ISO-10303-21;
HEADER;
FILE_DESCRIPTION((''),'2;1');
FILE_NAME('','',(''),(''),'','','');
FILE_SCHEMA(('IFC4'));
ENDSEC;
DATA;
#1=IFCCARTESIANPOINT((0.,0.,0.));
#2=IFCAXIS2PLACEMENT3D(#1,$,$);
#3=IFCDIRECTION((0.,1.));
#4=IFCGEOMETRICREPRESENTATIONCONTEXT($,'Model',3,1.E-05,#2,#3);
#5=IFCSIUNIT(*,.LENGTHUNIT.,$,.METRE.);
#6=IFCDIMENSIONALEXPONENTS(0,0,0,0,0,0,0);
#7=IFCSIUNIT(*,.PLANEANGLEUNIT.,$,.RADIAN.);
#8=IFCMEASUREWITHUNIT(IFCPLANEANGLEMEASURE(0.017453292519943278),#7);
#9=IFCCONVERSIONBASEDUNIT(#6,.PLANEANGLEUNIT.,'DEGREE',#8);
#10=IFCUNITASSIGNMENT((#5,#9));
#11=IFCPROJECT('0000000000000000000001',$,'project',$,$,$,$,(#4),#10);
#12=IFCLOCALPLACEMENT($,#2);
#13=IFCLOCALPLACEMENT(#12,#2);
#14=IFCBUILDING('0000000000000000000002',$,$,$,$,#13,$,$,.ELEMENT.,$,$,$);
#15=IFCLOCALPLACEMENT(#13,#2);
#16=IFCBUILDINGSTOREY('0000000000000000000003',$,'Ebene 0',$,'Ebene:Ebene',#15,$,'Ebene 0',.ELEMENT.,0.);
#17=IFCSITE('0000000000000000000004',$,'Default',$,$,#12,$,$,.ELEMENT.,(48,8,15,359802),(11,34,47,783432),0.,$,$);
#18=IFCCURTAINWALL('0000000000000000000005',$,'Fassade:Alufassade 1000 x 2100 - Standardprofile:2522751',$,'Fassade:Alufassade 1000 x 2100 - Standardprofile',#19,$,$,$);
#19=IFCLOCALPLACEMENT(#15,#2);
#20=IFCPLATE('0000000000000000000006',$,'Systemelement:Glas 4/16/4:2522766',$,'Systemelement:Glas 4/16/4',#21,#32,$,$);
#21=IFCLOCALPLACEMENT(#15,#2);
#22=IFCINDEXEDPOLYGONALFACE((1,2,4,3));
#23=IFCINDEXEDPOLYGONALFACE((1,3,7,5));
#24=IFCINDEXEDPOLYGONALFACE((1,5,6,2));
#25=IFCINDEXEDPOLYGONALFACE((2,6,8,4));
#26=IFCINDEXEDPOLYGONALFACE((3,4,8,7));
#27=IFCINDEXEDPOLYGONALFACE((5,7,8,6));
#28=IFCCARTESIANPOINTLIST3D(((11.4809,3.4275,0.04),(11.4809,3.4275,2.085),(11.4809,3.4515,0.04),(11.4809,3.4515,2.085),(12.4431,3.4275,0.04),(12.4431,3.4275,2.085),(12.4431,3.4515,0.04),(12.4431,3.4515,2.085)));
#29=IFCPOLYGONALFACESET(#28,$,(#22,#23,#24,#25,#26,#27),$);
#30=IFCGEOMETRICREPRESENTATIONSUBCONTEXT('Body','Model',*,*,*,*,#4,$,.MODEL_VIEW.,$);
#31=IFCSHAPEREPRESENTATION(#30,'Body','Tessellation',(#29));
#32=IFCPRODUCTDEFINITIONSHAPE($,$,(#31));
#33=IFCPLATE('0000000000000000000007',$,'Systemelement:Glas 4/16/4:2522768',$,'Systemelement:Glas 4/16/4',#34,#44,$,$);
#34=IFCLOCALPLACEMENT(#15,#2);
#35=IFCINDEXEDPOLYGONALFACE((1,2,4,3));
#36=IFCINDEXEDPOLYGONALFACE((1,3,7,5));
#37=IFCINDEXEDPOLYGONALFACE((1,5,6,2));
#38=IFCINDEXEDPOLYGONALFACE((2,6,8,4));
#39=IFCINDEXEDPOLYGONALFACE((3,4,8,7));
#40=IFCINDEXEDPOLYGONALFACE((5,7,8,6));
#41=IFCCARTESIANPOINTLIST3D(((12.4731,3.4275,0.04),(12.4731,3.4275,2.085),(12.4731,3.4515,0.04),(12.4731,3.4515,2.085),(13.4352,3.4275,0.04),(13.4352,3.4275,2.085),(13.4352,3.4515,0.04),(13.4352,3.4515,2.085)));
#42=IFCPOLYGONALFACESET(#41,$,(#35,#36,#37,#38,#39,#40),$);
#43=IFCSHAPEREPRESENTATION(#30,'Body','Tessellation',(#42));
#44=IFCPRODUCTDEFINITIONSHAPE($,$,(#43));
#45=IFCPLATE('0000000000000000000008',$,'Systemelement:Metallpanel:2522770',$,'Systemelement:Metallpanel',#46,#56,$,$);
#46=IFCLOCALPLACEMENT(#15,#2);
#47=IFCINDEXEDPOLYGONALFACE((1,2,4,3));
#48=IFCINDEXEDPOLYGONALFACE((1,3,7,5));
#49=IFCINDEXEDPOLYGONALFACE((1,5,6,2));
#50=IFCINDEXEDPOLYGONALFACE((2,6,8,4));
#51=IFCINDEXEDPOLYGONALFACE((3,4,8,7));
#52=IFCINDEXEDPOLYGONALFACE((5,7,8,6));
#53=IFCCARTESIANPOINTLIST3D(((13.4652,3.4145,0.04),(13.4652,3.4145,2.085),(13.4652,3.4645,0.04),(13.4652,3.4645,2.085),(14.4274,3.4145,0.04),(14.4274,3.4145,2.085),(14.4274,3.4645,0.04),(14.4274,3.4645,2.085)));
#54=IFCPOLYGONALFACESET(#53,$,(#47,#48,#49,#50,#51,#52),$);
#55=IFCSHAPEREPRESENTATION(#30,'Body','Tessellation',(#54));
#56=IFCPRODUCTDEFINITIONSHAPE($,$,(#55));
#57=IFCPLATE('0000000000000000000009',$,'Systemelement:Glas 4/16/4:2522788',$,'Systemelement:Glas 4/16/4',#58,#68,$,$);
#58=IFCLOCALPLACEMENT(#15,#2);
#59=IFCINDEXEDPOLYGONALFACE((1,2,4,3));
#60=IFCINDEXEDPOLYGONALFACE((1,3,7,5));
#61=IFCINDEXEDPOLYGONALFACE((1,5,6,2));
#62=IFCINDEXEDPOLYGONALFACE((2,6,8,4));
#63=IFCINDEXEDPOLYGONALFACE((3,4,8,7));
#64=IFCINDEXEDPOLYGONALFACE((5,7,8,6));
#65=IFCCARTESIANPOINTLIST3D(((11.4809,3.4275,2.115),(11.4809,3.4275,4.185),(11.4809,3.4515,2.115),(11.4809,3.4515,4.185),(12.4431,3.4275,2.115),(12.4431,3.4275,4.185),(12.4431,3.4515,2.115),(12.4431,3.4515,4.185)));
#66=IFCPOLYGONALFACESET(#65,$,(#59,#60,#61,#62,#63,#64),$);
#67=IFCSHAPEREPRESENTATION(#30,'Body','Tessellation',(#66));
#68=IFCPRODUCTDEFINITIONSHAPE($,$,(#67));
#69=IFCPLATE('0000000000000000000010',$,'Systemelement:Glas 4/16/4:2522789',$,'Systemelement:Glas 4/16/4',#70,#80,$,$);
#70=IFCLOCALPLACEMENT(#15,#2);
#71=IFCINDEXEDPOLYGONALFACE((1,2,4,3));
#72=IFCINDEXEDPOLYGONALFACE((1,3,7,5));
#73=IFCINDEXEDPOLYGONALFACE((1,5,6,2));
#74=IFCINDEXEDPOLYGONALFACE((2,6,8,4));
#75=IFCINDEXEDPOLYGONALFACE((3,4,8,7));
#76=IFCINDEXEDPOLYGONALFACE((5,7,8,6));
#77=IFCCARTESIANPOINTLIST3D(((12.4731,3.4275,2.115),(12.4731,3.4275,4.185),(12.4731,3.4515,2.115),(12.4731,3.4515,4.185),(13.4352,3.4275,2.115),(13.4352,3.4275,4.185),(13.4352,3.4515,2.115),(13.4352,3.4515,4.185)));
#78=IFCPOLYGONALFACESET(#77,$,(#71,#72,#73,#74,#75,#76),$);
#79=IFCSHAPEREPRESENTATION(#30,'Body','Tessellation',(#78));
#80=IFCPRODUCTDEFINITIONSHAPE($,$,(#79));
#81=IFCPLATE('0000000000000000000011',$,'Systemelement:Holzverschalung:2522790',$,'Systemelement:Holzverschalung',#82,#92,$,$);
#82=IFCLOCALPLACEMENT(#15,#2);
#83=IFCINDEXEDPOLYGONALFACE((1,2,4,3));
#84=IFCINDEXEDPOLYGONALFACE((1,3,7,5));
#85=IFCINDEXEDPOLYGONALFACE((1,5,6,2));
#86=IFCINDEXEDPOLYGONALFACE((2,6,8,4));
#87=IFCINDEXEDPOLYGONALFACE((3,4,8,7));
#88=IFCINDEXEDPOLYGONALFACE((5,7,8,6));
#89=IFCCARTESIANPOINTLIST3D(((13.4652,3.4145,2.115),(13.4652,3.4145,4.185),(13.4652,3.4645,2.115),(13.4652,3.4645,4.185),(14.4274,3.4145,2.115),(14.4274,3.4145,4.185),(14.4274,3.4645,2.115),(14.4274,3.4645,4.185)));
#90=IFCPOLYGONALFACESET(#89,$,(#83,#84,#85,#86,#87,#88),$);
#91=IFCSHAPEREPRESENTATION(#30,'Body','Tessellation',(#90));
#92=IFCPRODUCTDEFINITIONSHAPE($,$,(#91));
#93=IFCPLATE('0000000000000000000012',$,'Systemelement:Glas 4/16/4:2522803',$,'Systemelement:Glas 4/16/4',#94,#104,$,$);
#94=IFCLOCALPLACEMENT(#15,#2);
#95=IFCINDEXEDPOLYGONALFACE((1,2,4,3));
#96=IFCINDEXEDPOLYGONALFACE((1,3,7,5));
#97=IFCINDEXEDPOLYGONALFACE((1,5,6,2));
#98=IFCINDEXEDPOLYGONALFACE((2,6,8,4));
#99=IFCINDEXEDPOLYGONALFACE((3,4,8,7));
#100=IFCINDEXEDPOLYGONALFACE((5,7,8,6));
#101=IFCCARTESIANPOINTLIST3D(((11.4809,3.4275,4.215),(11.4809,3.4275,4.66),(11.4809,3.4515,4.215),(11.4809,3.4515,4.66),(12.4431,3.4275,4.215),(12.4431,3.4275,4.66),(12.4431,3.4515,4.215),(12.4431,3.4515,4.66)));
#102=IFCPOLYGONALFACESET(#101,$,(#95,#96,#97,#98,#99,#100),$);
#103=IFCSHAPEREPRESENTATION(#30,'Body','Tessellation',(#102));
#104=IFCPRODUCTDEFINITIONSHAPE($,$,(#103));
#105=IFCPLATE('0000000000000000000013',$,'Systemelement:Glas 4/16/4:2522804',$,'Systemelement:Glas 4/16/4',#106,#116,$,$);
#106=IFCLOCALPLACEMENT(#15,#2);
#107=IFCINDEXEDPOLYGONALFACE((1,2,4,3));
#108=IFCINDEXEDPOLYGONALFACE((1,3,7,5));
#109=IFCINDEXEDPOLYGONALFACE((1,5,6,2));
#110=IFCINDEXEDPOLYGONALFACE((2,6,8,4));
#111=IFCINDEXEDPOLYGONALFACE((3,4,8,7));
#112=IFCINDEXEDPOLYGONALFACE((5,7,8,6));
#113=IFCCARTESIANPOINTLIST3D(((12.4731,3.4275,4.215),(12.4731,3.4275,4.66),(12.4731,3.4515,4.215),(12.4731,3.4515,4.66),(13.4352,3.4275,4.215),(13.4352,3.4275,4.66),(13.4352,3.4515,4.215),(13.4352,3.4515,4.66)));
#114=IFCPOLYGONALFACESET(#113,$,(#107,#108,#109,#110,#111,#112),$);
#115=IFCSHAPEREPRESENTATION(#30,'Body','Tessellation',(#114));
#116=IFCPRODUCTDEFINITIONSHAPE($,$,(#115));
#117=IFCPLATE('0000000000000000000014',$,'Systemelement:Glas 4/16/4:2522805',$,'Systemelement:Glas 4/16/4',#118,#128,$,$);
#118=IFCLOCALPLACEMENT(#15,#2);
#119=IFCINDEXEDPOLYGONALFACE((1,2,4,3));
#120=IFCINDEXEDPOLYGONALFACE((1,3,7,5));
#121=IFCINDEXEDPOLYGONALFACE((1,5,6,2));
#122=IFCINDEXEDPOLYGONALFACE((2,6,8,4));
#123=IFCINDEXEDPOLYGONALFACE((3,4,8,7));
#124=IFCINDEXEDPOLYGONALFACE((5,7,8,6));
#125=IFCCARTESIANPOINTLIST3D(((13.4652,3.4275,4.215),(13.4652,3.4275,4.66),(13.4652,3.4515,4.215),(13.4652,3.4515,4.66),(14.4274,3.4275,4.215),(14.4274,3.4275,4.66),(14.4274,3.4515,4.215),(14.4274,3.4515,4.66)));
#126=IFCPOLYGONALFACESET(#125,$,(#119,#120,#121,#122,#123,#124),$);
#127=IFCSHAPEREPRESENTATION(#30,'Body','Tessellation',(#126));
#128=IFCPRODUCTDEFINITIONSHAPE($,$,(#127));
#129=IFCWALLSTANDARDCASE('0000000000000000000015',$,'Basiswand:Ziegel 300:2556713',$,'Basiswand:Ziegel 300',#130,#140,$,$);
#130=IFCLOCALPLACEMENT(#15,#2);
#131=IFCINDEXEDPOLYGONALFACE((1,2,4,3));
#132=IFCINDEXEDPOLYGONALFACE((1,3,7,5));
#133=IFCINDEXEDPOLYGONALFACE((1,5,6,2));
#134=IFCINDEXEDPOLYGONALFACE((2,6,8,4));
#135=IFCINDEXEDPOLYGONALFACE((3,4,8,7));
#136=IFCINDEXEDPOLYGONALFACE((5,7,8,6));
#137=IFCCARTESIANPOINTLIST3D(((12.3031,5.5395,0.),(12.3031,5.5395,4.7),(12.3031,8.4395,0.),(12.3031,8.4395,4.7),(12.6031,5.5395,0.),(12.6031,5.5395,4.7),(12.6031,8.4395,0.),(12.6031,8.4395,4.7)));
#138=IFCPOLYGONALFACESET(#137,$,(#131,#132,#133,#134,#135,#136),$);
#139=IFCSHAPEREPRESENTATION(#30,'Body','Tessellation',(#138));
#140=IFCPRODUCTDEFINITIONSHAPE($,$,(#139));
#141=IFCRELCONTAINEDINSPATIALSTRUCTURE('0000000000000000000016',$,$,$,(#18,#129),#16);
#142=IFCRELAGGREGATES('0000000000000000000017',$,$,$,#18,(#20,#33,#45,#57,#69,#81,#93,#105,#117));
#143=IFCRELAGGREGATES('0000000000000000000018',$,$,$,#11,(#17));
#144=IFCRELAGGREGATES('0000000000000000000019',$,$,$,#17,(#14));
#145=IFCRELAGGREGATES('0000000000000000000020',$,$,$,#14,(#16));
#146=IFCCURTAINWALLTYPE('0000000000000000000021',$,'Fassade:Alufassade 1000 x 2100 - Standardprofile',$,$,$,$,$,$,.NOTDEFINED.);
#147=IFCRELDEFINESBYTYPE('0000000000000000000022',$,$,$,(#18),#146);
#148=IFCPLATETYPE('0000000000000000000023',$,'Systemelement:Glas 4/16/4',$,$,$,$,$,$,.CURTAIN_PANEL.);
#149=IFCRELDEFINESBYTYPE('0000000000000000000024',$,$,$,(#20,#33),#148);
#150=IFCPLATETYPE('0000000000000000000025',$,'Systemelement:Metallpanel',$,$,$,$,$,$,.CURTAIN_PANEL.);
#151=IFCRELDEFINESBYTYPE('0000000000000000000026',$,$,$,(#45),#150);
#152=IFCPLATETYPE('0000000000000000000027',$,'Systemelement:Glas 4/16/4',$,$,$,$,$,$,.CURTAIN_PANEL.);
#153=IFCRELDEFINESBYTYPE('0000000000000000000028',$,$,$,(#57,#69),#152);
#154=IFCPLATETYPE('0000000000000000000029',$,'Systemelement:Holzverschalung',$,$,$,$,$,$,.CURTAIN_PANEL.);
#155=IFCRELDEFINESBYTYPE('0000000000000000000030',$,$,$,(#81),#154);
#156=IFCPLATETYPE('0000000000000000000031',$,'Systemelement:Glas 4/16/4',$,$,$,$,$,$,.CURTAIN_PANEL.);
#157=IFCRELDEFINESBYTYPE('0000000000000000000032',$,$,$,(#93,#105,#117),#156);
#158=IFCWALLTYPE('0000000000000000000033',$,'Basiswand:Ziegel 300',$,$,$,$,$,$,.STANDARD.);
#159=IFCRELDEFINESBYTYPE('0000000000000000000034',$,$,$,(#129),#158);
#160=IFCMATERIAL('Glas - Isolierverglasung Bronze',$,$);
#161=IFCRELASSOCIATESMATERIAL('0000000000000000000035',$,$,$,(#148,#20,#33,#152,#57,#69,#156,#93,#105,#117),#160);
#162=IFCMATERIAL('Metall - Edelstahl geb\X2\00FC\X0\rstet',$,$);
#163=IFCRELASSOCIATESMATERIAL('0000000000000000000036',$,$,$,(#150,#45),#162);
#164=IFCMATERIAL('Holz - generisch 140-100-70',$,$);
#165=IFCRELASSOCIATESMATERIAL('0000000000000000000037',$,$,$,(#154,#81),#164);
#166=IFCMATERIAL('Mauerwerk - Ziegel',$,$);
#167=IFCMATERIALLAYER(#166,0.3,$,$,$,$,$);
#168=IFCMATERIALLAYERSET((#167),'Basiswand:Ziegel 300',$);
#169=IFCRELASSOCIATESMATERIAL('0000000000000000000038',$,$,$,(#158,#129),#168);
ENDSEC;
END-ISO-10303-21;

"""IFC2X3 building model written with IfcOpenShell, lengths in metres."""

from ifc_helpers import new_model, entity, si_unit, converted_unit, direction, frame, frame_2d, origin, origin_2d_with_axis, place, context, subcontext, project, spatial, polyline, rectangle, extrude, clip, bounded_halfspace, source, transform, mapped, material, layer, layer_set, layer_usage, type_object, type_shapes, element, aggregate, save


model = new_model("IFC2X3")

# Units and contexts
model_context = context("Model", 3, precision=1e-05, world=origin(), true_north=direction((0.0, 1.0)))
body_context = subcontext(model_context, "Body", "Model", "MODEL_VIEW")
ifc_project = project(units=[si_unit("LENGTHUNIT", "METRE"), converted_unit("PLANEANGLEUNIT", "DEGREE", entity("IfcPlaneAngleMeasure", 0.017453292519943278), si_unit("PLANEANGLEUNIT", "RADIAN"), dimensions=[0, 0, 0, 0, 0, 0, 0])], contexts=[model_context])

# Site, building, storey
site_placement = place(None, origin())
site = spatial("IfcSite", under=ifc_project, at=site_placement, Name="Default", CompositionType="ELEMENT", RefLatitude=(48, 8, 15, 359802), RefLongitude=(11, 34, 47, 783432), RefElevation=0.0)
building_placement = place(site_placement, origin())
building = spatial("IfcBuilding", under=site, at=building_placement, CompositionType="ELEMENT")
storey_placement = place(building_placement, origin())
storey = spatial("IfcBuildingStorey", under=building, at=storey_placement, Name="Ebene 0", ObjectType="Ebene:Ebene", LongName="Ebene 0", CompositionType="ELEMENT", Elevation=0.0)

# Curtain wall, plates
curtain_wall_type = type_object("IfcCurtainWallType", Name="Fassade:Alufassade 1000 x 2100 - Standardprofile", PredefinedType="NOTDEFINED")
curtain_wall_placement = place(storey_placement, origin())
curtain_wall = element("IfcCurtainWall", 1, at=curtain_wall_placement, inside=storey, type_object=curtain_wall_type, Name="Fassade:Alufassade 1000 x 2100 - Standardprofile:2522751", ObjectType="Fassade:Alufassade 1000 x 2100 - Standardprofile")
ifc_material_1 = material(Name="Glas - Isolierverglasung Bronze")
plate_type_1 = type_object("IfcPlateType", Name="Systemelement:Glas 4/16/4", PredefinedType="CURTAIN_PANEL", material=ifc_material_1)
shared_shape_1 = source(origin(), body_context, "Body", "SweptSolid", [
    extrude(rectangle(XDim=0.024, YDim=0.9621, at=origin_2d_with_axis()), frame((0.0, 0.0, 0.0), z_axis=(0.0, 0.0, 1.0), x_axis=(0.0, 1.0, 0.0)), (0.0, 0.0, 1.0), 2.045),
])
type_shapes(plate_type_1, [shared_shape_1])
plate_1_placement = place(curtain_wall_placement, frame((11.962, 3.4395, 0.04)))
plate_1 = element("IfcPlate", 2, at=plate_1_placement, type_object=plate_type_1, material=ifc_material_1, Name="Systemelement:Glas 4/16/4:2522766", ObjectType="Systemelement:Glas 4/16/4", context=body_context, shape_type="MappedRepresentation", body=[
    mapped(shared_shape_1, transform((0.0, 0.0, 0.0), scale=1.0)),
])
plate_2_placement = place(curtain_wall_placement, frame((12.9542, 3.4395, 0.04)))
plate_2 = element("IfcPlate", 3, at=plate_2_placement, type_object=plate_type_1, material=ifc_material_1, Name="Systemelement:Glas 4/16/4:2522768", ObjectType="Systemelement:Glas 4/16/4", context=body_context, shape_type="MappedRepresentation", body=[
    mapped(shared_shape_1, transform((0.0, 0.0, 0.0), scale=1.0)),
])
ifc_material_2 = material(Name="Metall - Edelstahl gebürstet")
plate_type_2 = type_object("IfcPlateType", Name="Systemelement:Metallpanel", PredefinedType="CURTAIN_PANEL", material=ifc_material_2)
shared_shape_2 = source(origin(), body_context, "Body", "SweptSolid", [
    extrude(rectangle(XDim=0.05, YDim=0.9621, at=origin_2d_with_axis()), frame((0.0, 0.0, 0.0), z_axis=(0.0, 0.0, 1.0), x_axis=(0.0, 1.0, 0.0)), (0.0, 0.0, 1.0), 2.045),
])
type_shapes(plate_type_2, [shared_shape_2])
plate_3_placement = place(curtain_wall_placement, frame((13.9463, 3.4395, 0.04)))
plate_3 = element("IfcPlate", 4, at=plate_3_placement, type_object=plate_type_2, material=ifc_material_2, Name="Systemelement:Metallpanel:2522770", ObjectType="Systemelement:Metallpanel", context=body_context, shape_type="MappedRepresentation", body=[
    mapped(shared_shape_2, transform((0.0, 0.0, 0.0), scale=1.0)),
])
plate_type_3 = type_object("IfcPlateType", Name="Systemelement:Glas 4/16/4", PredefinedType="CURTAIN_PANEL", material=ifc_material_1)
shared_shape_3 = source(origin(), body_context, "Body", "SweptSolid", [
    extrude(rectangle(XDim=0.024, YDim=0.9621, at=origin_2d_with_axis()), frame((0.0, 0.0, 0.0), z_axis=(0.0, 0.0, 1.0), x_axis=(0.0, 1.0, 0.0)), (0.0, 0.0, 1.0), 2.07),
])
type_shapes(plate_type_3, [shared_shape_3])
plate_4_placement = place(curtain_wall_placement, frame((11.962, 3.4395, 2.115)))
plate_4 = element("IfcPlate", 5, at=plate_4_placement, type_object=plate_type_3, material=ifc_material_1, Name="Systemelement:Glas 4/16/4:2522788", ObjectType="Systemelement:Glas 4/16/4", context=body_context, shape_type="MappedRepresentation", body=[
    mapped(shared_shape_3, transform((0.0, 0.0, 0.0), scale=1.0)),
])
plate_5_placement = place(curtain_wall_placement, frame((12.9542, 3.4395, 2.115)))
plate_5 = element("IfcPlate", 6, at=plate_5_placement, type_object=plate_type_3, material=ifc_material_1, Name="Systemelement:Glas 4/16/4:2522789", ObjectType="Systemelement:Glas 4/16/4", context=body_context, shape_type="MappedRepresentation", body=[
    mapped(shared_shape_3, transform((0.0, 0.0, 0.0), scale=1.0)),
])
ifc_material_3 = material(Name="Holz - generisch 140-100-70")
plate_type_4 = type_object("IfcPlateType", Name="Systemelement:Holzverschalung", PredefinedType="CURTAIN_PANEL", material=ifc_material_3)
shared_shape_4 = source(origin(), body_context, "Body", "SweptSolid", [
    extrude(rectangle(XDim=0.05, YDim=0.9621, at=origin_2d_with_axis()), frame((0.0, 0.0, 0.0), z_axis=(0.0, 0.0, 1.0), x_axis=(0.0, 1.0, 0.0)), (0.0, 0.0, 1.0), 2.07),
])
type_shapes(plate_type_4, [shared_shape_4])
plate_6_placement = place(curtain_wall_placement, frame((13.9463, 3.4395, 2.115)))
plate_6 = element("IfcPlate", 7, at=plate_6_placement, type_object=plate_type_4, material=ifc_material_3, Name="Systemelement:Holzverschalung:2522790", ObjectType="Systemelement:Holzverschalung", context=body_context, shape_type="MappedRepresentation", body=[
    mapped(shared_shape_4, transform((0.0, 0.0, 0.0), scale=1.0)),
])
plate_type_5 = type_object("IfcPlateType", Name="Systemelement:Glas 4/16/4", PredefinedType="CURTAIN_PANEL", material=ifc_material_1)
shared_shape_5 = source(origin(), body_context, "Body", "SweptSolid", [
    extrude(rectangle(XDim=0.024, YDim=0.9621, at=origin_2d_with_axis()), frame((0.0, 0.0, 0.0), z_axis=(0.0, 0.0, 1.0), x_axis=(0.0, 1.0, 0.0)), (0.0, 0.0, 1.0), 0.445),
])
type_shapes(plate_type_5, [shared_shape_5])
plate_7_placement = place(curtain_wall_placement, frame((11.962, 3.4395, 4.215)))
plate_7 = element("IfcPlate", 8, at=plate_7_placement, type_object=plate_type_5, material=ifc_material_1, Name="Systemelement:Glas 4/16/4:2522803", ObjectType="Systemelement:Glas 4/16/4", context=body_context, shape_type="MappedRepresentation", body=[
    mapped(shared_shape_5, transform((0.0, 0.0, 0.0), scale=1.0)),
])
plate_8_placement = place(curtain_wall_placement, frame((12.9542, 3.4395, 4.215)))
plate_8 = element("IfcPlate", 9, at=plate_8_placement, type_object=plate_type_5, material=ifc_material_1, Name="Systemelement:Glas 4/16/4:2522804", ObjectType="Systemelement:Glas 4/16/4", context=body_context, shape_type="MappedRepresentation", body=[
    mapped(shared_shape_5, transform((0.0, 0.0, 0.0), scale=1.0)),
])
plate_9_placement = place(curtain_wall_placement, frame((13.9463, 3.4395, 4.215)))
plate_9 = element("IfcPlate", 10, at=plate_9_placement, type_object=plate_type_5, material=ifc_material_1, Name="Systemelement:Glas 4/16/4:2522805", ObjectType="Systemelement:Glas 4/16/4", context=body_context, shape_type="MappedRepresentation", body=[
    mapped(shared_shape_5, transform((0.0, 0.0, 0.0), scale=1.0)),
])
aggregate(curtain_wall, [plate_1, plate_2, plate_3, plate_4, plate_5, plate_6, plate_7, plate_8, plate_9])

# Wall
ifc_material_4 = material(Name="Mauerwerk - Ziegel")
ifc_layer = layer(ifc_material_4, 0.3)
ifc_layer_set = layer_set([ifc_layer], Name="Basiswand:Ziegel 300")
ifc_layer_usage = layer_usage(ifc_layer_set, "AXIS2", "NEGATIVE", 0.15)
wall_type = type_object("IfcWallType", Name="Basiswand:Ziegel 300", PredefinedType="STANDARD", material=ifc_layer_set)
wall_placement = place(storey_placement, frame((12.4531, 5.5395, 0.0), z_axis=(0.0, 0.0, 1.0), x_axis=(0.0, 1.0, 0.0)))
element("IfcWallStandardCase", 11, at=wall_placement, inside=storey, type_object=wall_type, material=ifc_layer_usage, Name="Basiswand:Ziegel 300:2556713", ObjectType="Basiswand:Ziegel 300", context=body_context, shape_type="Clipping", body=[
    clip(extrude(rectangle(XDim=2.9, YDim=0.3, at=frame_2d((1.45, 0.0), x_axis=(-1.0, 0.0))), origin(), (0.0, 0.0, 1.0), 4.7), bounded_halfspace(frame((0.0, -0.15, 4.7), z_axis=(0.0, 0.0, -1.0), x_axis=(-1.0, 0.0, 0.0)), True, frame((0.0, -0.15, 4.7)), polyline([(0.0, 0.0), (2.9, 0.0), (2.9, 0.3), (0.0, 0.3), (0.0, 0.0)]))),
])

save(model, "model.ifc")
